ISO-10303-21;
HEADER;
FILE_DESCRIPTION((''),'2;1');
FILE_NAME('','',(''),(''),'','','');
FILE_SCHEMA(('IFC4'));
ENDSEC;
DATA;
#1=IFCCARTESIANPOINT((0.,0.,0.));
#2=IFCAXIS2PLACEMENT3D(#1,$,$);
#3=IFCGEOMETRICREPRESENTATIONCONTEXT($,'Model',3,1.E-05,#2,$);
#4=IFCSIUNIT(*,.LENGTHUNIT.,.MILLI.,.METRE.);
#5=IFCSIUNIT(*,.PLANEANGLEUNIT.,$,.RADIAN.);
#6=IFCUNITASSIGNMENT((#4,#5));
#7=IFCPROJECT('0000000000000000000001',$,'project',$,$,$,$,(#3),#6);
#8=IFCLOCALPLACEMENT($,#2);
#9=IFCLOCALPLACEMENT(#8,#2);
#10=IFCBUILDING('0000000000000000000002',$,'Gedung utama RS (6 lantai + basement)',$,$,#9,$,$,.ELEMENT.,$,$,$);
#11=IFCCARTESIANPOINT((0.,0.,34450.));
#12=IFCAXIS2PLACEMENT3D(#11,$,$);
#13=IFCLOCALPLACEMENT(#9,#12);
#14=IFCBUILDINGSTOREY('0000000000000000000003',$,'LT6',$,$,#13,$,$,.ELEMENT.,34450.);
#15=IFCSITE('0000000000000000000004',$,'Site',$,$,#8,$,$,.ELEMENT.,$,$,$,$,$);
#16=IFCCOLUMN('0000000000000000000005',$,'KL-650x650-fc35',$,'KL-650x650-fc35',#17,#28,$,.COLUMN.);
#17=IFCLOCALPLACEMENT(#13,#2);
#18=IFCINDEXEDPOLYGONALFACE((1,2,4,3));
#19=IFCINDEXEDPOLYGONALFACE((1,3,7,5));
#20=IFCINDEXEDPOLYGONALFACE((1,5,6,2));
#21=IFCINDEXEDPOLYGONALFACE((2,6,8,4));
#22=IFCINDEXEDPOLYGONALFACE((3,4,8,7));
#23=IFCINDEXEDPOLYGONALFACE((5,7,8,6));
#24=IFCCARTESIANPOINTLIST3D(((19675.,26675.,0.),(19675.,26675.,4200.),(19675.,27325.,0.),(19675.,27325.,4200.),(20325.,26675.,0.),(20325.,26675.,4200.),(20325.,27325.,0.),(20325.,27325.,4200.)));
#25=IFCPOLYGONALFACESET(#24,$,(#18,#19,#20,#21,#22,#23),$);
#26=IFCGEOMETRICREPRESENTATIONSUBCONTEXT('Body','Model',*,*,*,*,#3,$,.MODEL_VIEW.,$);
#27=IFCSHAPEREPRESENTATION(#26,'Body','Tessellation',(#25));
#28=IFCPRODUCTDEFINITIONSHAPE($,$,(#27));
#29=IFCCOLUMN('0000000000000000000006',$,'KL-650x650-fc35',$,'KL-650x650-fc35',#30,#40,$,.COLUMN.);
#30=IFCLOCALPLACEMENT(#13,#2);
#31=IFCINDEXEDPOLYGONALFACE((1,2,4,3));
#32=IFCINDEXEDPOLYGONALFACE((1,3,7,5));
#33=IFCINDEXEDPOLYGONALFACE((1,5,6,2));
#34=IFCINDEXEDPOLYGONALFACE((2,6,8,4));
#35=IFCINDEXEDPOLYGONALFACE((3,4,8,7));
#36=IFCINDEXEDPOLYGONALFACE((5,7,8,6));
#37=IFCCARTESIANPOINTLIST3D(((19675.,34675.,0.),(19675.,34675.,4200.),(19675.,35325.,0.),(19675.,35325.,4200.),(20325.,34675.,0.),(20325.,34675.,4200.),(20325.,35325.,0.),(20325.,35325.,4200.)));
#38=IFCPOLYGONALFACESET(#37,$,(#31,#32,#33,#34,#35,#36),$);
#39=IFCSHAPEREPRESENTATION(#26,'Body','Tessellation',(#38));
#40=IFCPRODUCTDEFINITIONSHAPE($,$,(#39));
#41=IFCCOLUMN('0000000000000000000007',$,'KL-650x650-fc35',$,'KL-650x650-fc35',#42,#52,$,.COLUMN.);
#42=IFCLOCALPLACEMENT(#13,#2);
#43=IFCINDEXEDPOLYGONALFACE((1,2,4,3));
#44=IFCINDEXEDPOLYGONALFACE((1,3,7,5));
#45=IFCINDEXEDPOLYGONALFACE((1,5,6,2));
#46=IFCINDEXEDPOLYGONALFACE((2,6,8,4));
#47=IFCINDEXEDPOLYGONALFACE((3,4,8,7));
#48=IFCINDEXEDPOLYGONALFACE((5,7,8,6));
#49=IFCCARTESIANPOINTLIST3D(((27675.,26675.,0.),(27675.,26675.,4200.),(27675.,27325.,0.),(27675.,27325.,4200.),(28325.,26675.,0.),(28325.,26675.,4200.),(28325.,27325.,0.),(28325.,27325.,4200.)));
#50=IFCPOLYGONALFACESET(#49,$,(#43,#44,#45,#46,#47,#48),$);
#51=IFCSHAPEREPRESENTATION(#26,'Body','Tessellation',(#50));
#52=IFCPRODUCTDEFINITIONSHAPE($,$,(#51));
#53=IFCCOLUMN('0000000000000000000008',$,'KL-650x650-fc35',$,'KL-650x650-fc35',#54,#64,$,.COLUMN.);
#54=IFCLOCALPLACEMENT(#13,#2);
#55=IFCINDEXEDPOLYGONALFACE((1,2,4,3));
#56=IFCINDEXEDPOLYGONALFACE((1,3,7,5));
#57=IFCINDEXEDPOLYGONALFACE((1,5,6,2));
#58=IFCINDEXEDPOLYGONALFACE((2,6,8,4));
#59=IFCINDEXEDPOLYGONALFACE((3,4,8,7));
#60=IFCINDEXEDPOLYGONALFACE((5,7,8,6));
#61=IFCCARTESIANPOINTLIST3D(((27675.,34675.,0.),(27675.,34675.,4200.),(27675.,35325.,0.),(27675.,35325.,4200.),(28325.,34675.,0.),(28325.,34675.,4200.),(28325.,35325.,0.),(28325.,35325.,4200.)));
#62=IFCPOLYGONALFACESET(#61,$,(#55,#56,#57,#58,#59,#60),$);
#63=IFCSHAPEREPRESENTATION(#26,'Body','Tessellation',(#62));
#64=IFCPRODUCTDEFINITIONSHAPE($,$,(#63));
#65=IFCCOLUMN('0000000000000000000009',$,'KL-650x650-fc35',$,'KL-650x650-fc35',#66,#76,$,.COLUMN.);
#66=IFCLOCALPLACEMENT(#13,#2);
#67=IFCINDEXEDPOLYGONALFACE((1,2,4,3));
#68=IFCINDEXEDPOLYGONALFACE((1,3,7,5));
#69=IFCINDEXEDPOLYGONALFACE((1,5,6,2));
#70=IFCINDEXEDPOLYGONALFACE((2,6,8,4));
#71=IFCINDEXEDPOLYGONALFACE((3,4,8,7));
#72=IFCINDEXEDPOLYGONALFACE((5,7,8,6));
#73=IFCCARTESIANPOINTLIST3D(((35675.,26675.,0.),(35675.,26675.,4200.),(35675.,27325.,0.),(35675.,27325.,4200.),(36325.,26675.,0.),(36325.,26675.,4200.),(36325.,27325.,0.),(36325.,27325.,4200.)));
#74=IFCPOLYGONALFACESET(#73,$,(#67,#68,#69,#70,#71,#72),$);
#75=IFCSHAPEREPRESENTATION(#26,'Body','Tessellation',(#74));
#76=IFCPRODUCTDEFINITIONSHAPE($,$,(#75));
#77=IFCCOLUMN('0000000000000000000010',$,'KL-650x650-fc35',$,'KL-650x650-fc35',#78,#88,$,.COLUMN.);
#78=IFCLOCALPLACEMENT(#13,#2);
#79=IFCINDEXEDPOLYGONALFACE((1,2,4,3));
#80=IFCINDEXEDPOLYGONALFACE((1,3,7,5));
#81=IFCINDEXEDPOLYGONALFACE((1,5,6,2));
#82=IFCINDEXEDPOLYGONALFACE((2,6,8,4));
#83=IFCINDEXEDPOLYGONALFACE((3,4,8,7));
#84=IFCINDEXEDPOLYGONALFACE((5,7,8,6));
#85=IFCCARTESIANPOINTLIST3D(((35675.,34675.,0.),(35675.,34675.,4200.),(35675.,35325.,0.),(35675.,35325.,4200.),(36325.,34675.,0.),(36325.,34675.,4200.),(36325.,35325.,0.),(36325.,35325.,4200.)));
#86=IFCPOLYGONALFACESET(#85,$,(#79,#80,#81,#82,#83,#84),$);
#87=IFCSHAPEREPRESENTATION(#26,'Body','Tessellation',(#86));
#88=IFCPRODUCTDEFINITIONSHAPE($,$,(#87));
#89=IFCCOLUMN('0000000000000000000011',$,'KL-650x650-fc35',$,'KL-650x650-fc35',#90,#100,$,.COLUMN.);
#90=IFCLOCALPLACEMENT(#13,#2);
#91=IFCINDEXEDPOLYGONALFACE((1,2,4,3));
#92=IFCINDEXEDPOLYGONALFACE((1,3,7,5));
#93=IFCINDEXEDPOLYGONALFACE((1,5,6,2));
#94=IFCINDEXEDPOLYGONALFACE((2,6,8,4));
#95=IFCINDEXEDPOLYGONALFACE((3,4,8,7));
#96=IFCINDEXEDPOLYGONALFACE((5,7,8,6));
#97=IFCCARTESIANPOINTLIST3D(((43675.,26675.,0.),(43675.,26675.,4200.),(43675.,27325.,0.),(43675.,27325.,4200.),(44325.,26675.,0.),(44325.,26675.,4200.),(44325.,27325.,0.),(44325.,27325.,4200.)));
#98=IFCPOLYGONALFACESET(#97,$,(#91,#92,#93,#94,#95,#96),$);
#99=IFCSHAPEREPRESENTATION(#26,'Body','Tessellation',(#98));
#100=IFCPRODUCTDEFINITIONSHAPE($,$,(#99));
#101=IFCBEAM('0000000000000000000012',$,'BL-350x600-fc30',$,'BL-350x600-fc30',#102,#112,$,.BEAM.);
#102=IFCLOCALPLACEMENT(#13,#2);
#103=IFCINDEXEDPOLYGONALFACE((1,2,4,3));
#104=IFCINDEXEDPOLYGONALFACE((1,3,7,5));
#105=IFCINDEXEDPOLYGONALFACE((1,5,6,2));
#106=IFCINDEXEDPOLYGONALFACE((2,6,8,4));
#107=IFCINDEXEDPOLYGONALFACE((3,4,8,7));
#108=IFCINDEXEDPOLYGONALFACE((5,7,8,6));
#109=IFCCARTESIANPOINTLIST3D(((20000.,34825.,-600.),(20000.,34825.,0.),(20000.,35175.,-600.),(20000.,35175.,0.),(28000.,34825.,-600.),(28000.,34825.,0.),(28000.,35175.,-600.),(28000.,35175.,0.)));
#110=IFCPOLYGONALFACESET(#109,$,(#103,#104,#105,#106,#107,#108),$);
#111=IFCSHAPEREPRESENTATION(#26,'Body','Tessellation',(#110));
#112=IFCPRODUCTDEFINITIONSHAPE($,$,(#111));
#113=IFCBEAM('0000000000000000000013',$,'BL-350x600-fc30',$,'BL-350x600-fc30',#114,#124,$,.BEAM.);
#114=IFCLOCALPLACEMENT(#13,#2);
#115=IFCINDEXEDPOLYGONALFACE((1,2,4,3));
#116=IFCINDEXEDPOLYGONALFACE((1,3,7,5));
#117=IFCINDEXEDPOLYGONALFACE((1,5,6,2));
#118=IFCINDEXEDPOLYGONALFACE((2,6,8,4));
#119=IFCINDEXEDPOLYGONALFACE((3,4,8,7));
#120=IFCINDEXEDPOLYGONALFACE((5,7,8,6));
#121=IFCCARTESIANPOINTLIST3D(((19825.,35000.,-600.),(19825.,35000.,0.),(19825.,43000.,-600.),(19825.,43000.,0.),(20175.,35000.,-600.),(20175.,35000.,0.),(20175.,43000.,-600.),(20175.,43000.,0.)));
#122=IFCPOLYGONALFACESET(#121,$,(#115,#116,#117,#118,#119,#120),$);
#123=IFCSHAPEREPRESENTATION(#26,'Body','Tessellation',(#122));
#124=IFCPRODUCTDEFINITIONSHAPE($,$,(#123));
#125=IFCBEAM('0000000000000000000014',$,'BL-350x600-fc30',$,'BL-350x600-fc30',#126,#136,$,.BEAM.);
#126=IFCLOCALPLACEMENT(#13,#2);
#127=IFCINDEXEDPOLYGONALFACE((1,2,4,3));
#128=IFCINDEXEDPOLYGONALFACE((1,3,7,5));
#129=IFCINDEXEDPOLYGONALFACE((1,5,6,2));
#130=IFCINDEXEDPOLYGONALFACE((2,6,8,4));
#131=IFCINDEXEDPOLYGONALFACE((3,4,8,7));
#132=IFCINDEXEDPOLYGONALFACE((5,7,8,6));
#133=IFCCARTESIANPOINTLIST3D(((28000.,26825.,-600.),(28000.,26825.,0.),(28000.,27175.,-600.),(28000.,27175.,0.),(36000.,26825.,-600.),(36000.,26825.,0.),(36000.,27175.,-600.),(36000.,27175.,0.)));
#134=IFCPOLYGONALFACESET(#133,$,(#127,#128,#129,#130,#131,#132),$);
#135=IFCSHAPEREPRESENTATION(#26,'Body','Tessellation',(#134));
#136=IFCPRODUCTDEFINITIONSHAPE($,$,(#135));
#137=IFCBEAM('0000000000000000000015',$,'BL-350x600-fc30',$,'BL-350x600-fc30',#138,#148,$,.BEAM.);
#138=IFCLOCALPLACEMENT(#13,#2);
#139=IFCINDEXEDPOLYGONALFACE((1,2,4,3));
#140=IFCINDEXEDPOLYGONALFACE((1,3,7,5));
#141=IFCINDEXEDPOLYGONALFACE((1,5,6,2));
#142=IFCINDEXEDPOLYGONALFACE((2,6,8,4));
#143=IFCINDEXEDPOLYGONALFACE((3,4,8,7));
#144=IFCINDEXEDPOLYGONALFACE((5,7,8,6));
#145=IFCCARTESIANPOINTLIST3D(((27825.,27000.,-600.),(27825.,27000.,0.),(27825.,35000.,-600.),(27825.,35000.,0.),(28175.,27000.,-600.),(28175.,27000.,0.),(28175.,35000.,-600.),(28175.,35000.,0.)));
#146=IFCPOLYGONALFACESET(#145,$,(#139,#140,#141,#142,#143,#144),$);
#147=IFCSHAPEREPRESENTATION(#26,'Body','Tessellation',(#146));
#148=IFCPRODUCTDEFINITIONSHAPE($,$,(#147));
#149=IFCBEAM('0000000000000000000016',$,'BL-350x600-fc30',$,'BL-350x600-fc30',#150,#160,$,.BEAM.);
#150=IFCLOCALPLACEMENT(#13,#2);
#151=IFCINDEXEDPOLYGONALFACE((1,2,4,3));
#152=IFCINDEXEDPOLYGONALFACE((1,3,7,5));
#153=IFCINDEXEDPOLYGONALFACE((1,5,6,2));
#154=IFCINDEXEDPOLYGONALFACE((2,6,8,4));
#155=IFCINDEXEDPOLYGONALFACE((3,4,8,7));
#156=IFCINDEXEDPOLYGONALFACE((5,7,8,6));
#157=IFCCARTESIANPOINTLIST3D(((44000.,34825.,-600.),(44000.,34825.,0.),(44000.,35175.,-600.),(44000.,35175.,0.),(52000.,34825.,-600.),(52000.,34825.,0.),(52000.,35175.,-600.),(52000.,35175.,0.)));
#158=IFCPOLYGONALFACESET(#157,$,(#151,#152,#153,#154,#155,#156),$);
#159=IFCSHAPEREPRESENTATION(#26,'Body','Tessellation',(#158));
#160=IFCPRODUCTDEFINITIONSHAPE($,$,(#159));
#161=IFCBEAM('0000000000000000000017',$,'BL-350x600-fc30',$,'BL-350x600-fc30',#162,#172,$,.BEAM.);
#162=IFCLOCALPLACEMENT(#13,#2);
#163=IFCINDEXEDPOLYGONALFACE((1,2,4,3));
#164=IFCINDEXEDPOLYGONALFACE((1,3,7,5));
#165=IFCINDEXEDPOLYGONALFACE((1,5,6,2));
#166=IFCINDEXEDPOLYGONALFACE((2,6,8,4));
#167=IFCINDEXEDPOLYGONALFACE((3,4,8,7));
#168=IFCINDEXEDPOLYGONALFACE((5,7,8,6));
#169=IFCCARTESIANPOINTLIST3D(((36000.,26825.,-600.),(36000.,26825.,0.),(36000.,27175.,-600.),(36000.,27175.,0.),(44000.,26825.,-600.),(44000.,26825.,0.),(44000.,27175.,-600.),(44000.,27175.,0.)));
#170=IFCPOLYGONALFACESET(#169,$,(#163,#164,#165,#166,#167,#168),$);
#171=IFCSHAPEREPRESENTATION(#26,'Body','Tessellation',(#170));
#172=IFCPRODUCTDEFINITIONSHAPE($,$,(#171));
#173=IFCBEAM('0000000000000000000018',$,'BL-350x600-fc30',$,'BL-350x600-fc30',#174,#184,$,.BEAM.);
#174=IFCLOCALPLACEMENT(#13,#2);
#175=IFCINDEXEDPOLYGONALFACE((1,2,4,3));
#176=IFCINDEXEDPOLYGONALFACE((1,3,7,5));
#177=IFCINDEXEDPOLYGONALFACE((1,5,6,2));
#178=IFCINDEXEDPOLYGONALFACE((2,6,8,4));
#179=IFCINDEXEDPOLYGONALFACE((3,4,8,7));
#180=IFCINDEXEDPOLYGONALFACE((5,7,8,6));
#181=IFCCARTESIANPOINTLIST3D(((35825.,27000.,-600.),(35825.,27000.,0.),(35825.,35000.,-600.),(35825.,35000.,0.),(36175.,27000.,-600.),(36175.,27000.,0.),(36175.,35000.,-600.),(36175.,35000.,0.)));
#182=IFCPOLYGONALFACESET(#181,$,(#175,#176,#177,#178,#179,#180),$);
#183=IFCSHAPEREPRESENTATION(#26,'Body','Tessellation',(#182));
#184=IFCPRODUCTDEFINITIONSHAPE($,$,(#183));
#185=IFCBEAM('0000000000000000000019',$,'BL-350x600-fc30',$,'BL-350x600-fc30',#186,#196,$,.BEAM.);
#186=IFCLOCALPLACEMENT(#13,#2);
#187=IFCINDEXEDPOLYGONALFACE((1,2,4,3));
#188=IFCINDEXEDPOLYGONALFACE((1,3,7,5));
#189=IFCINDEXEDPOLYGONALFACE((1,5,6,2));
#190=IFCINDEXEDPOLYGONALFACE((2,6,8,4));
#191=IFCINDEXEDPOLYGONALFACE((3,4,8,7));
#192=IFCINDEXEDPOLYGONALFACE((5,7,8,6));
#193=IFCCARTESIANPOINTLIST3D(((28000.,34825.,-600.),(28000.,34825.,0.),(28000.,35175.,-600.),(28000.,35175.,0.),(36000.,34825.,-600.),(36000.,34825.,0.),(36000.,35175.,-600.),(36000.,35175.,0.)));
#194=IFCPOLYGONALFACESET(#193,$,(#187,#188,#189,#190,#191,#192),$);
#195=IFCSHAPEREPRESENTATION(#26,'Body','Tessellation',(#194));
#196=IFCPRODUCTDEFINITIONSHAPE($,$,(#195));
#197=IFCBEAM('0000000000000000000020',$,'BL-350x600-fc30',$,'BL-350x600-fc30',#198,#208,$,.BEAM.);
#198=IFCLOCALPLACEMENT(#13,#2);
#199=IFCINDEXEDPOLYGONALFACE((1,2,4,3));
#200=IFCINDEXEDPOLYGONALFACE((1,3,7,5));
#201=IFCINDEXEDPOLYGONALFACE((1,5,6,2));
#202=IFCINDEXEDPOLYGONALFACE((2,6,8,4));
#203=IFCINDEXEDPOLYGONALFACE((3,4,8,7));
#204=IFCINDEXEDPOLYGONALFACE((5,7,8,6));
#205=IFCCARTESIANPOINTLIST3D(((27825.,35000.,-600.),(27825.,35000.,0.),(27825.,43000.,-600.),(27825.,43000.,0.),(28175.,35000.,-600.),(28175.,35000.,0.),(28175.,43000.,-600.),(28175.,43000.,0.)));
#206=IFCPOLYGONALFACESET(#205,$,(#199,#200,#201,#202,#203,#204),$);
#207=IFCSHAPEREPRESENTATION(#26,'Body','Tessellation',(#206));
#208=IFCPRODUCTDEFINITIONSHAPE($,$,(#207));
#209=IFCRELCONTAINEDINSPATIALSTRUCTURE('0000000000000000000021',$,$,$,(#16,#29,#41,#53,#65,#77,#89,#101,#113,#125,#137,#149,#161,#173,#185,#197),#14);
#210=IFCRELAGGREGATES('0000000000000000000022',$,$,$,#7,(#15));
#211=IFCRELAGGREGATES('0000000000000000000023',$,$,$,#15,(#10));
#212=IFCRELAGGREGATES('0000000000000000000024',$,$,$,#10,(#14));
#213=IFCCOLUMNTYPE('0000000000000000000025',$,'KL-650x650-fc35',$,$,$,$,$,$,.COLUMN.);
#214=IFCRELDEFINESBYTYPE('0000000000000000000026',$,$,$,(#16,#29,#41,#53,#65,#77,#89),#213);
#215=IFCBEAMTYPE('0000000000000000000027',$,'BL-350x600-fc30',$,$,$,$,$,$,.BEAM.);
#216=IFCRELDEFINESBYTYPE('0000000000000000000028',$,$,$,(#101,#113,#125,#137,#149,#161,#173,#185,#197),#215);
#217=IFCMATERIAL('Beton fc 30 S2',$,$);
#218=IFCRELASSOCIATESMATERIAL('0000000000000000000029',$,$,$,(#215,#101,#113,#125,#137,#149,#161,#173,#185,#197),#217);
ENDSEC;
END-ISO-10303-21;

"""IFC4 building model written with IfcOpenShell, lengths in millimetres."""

from ifc_helpers import new_model, si_unit, frame, origin, origin_2d, place, context, subcontext, project, spatial, rectangle, extrude, material, material_profile, profile_set, profile_usage, type_object, element, save


model = new_model("IFC4")

# Units and contexts
model_context = context("Model", 3, precision=1e-05, world=origin())
body_context = subcontext(model_context, "Body", "Model", "MODEL_VIEW")
ifc_project = project(units=[si_unit("LENGTHUNIT", "METRE", prefix="MILLI"), si_unit("PLANEANGLEUNIT", "RADIAN")], contexts=[model_context])

# Site, building, storey
site_placement = place(None, origin())
site = spatial("IfcSite", under=ifc_project, at=site_placement, Name="Site", CompositionType="ELEMENT")
building_placement = place(site_placement, origin())
building = spatial("IfcBuilding", under=site, at=building_placement, Name="Gedung utama RS (6 lantai + basement)", CompositionType="ELEMENT")
storey_placement = place(building_placement, frame((0.0, 0.0, 34450.0)))
storey = spatial("IfcBuildingStorey", under=building, at=storey_placement, Name="LT6", CompositionType="ELEMENT", Elevation=34450.0)

# Columns
ifc_material_profile_1 = material_profile(None, rectangle(XDim=650.0, YDim=650.0, at=origin_2d()), Name="KL-650x650-fc35")
ifc_profile_set_1 = profile_set([ifc_material_profile_1], Name="KL-650x650-fc35")
ifc_profile_usage_1 = profile_usage(ifc_profile_set_1, cardinal=5)
column_type = type_object("IfcColumnType", Name="KL-650x650-fc35", PredefinedType="COLUMN", material=ifc_profile_set_1)
for number, where, z_axis, x_axis, name in (
    (1, (20000.0, 27000.0, 0.0), (0.0, 0.0, 1.0), (1.0, 0.0, 0.0), "KL-650x650-fc35"),
    (2, (20000.0, 35000.0, 0.0), (0.0, 0.0, 1.0), (1.0, 0.0, 0.0), "KL-650x650-fc35"),
    (3, (28000.0, 27000.0, 0.0), (0.0, 0.0, 1.0), (1.0, 0.0, 0.0), "KL-650x650-fc35"),
    (4, (28000.0, 35000.0, 0.0), (0.0, 0.0, 1.0), (1.0, 0.0, 0.0), "KL-650x650-fc35"),
    (5, (36000.0, 27000.0, 0.0), (0.0, 0.0, 1.0), (1.0, 0.0, 0.0), "KL-650x650-fc35"),
    (6, (36000.0, 35000.0, 0.0), (0.0, 0.0, 1.0), (1.0, 0.0, 0.0), "KL-650x650-fc35"),
    (7, (44000.0, 27000.0, 0.0), (0.0, 0.0, 1.0), (1.0, 0.0, 0.0), "KL-650x650-fc35"),
):
    element("IfcColumn", number, at=place(storey_placement, frame(where, z_axis=z_axis, x_axis=x_axis)), inside=storey, type_object=column_type, material=ifc_profile_usage_1, Name=name, ObjectType="KL-650x650-fc35", PredefinedType="COLUMN", context=body_context, shape_type="SweptSolid", body=[
        extrude(rectangle(XDim=650.0, YDim=650.0, at=origin_2d()), origin(), (0.0, 0.0, 1.0), 4200.0),
    ])

# Beams
ifc_material = material(Name="Beton fc 30 S2")
ifc_material_profile_2 = material_profile(ifc_material, rectangle(XDim=350.0, YDim=600.0, at=origin_2d()), Name="BL-350x600-fc30")
ifc_profile_set_2 = profile_set([ifc_material_profile_2], Name="BL-350x600-fc30")
ifc_profile_usage_2 = profile_usage(ifc_profile_set_2, cardinal=8)
beam_type = type_object("IfcBeamType", Name="BL-350x600-fc30", PredefinedType="BEAM", material=ifc_profile_set_2)
beam_1_placement = place(storey_placement, frame((20000.0, 35000.0, -300.0)))
element("IfcBeam", 8, at=beam_1_placement, inside=storey, type_object=beam_type, material=ifc_profile_usage_2, Name="BL-350x600-fc30", ObjectType="BL-350x600-fc30", PredefinedType="BEAM", context=body_context, shape_type="SweptSolid", body=[
    extrude(rectangle(XDim=350.0, YDim=600.0, at=origin_2d()), frame((0.0, 0.0, 0.0), z_axis=(1.0, 0.0, 0.0), x_axis=(0.0, 1.0, 0.0)), (0.0, 0.0, 1.0), 8000.0),
])
beam_2_placement = place(storey_placement, frame((20000.0, 35000.0, -300.0)))
element("IfcBeam", 9, at=beam_2_placement, inside=storey, type_object=beam_type, material=ifc_profile_usage_2, Name="BL-350x600-fc30", ObjectType="BL-350x600-fc30", PredefinedType="BEAM", context=body_context, shape_type="SweptSolid", body=[
    extrude(rectangle(XDim=350.0, YDim=600.0, at=origin_2d()), frame((0.0, 0.0, 0.0), z_axis=(0.0, 1.0, 0.0), x_axis=(-1.0, 0.0, 0.0)), (0.0, 0.0, 1.0), 8000.0),
])
beam_3_placement = place(storey_placement, frame((28000.0, 27000.0, -300.0)))
element("IfcBeam", 10, at=beam_3_placement, inside=storey, type_object=beam_type, material=ifc_profile_usage_2, Name="BL-350x600-fc30", ObjectType="BL-350x600-fc30", PredefinedType="BEAM", context=body_context, shape_type="SweptSolid", body=[
    extrude(rectangle(XDim=350.0, YDim=600.0, at=origin_2d()), frame((0.0, 0.0, 0.0), z_axis=(1.0, 0.0, 0.0), x_axis=(0.0, 1.0, 0.0)), (0.0, 0.0, 1.0), 8000.0),
])
beam_4_placement = place(storey_placement, frame((28000.0, 27000.0, -300.0)))
element("IfcBeam", 11, at=beam_4_placement, inside=storey, type_object=beam_type, material=ifc_profile_usage_2, Name="BL-350x600-fc30", ObjectType="BL-350x600-fc30", PredefinedType="BEAM", context=body_context, shape_type="SweptSolid", body=[
    extrude(rectangle(XDim=350.0, YDim=600.0, at=origin_2d()), frame((0.0, 0.0, 0.0), z_axis=(0.0, 1.0, 0.0), x_axis=(-1.0, 0.0, 0.0)), (0.0, 0.0, 1.0), 8000.0),
])
for number, where, name in (
    (12, (44000.0, 35000.0, -300.0), "BL-350x600-fc30"),
    (13, (36000.0, 27000.0, -300.0), "BL-350x600-fc30"),
):
    element("IfcBeam", number, at=place(storey_placement, frame(where)), inside=storey, type_object=beam_type, material=ifc_profile_usage_2, Name=name, ObjectType="BL-350x600-fc30", PredefinedType="BEAM", context=body_context, shape_type="SweptSolid", body=[
        extrude(rectangle(XDim=350.0, YDim=600.0, at=origin_2d()), frame((0.0, 0.0, 0.0), z_axis=(1.0, 0.0, 0.0), x_axis=(0.0, 1.0, 0.0)), (0.0, 0.0, 1.0), 8000.0),
    ])
beam_5_placement = place(storey_placement, frame((36000.0, 27000.0, -300.0)))
element("IfcBeam", 14, at=beam_5_placement, inside=storey, type_object=beam_type, material=ifc_profile_usage_2, Name="BL-350x600-fc30", ObjectType="BL-350x600-fc30", PredefinedType="BEAM", context=body_context, shape_type="SweptSolid", body=[
    extrude(rectangle(XDim=350.0, YDim=600.0, at=origin_2d()), frame((0.0, 0.0, 0.0), z_axis=(0.0, 1.0, 0.0), x_axis=(-1.0, 0.0, 0.0)), (0.0, 0.0, 1.0), 8000.0),
])
beam_6_placement = place(storey_placement, frame((28000.0, 35000.0, -300.0)))
element("IfcBeam", 15, at=beam_6_placement, inside=storey, type_object=beam_type, material=ifc_profile_usage_2, Name="BL-350x600-fc30", ObjectType="BL-350x600-fc30", PredefinedType="BEAM", context=body_context, shape_type="SweptSolid", body=[
    extrude(rectangle(XDim=350.0, YDim=600.0, at=origin_2d()), frame((0.0, 0.0, 0.0), z_axis=(1.0, 0.0, 0.0), x_axis=(0.0, 1.0, 0.0)), (0.0, 0.0, 1.0), 8000.0),
])
beam_7_placement = place(storey_placement, frame((28000.0, 35000.0, -300.0)))
element("IfcBeam", 16, at=beam_7_placement, inside=storey, type_object=beam_type, material=ifc_profile_usage_2, Name="BL-350x600-fc30", ObjectType="BL-350x600-fc30", PredefinedType="BEAM", context=body_context, shape_type="SweptSolid", body=[
    extrude(rectangle(XDim=350.0, YDim=600.0, at=origin_2d()), frame((0.0, 0.0, 0.0), z_axis=(0.0, 1.0, 0.0), x_axis=(-1.0, 0.0, 0.0)), (0.0, 0.0, 1.0), 8000.0),
])

save(model, "model.ifc")
